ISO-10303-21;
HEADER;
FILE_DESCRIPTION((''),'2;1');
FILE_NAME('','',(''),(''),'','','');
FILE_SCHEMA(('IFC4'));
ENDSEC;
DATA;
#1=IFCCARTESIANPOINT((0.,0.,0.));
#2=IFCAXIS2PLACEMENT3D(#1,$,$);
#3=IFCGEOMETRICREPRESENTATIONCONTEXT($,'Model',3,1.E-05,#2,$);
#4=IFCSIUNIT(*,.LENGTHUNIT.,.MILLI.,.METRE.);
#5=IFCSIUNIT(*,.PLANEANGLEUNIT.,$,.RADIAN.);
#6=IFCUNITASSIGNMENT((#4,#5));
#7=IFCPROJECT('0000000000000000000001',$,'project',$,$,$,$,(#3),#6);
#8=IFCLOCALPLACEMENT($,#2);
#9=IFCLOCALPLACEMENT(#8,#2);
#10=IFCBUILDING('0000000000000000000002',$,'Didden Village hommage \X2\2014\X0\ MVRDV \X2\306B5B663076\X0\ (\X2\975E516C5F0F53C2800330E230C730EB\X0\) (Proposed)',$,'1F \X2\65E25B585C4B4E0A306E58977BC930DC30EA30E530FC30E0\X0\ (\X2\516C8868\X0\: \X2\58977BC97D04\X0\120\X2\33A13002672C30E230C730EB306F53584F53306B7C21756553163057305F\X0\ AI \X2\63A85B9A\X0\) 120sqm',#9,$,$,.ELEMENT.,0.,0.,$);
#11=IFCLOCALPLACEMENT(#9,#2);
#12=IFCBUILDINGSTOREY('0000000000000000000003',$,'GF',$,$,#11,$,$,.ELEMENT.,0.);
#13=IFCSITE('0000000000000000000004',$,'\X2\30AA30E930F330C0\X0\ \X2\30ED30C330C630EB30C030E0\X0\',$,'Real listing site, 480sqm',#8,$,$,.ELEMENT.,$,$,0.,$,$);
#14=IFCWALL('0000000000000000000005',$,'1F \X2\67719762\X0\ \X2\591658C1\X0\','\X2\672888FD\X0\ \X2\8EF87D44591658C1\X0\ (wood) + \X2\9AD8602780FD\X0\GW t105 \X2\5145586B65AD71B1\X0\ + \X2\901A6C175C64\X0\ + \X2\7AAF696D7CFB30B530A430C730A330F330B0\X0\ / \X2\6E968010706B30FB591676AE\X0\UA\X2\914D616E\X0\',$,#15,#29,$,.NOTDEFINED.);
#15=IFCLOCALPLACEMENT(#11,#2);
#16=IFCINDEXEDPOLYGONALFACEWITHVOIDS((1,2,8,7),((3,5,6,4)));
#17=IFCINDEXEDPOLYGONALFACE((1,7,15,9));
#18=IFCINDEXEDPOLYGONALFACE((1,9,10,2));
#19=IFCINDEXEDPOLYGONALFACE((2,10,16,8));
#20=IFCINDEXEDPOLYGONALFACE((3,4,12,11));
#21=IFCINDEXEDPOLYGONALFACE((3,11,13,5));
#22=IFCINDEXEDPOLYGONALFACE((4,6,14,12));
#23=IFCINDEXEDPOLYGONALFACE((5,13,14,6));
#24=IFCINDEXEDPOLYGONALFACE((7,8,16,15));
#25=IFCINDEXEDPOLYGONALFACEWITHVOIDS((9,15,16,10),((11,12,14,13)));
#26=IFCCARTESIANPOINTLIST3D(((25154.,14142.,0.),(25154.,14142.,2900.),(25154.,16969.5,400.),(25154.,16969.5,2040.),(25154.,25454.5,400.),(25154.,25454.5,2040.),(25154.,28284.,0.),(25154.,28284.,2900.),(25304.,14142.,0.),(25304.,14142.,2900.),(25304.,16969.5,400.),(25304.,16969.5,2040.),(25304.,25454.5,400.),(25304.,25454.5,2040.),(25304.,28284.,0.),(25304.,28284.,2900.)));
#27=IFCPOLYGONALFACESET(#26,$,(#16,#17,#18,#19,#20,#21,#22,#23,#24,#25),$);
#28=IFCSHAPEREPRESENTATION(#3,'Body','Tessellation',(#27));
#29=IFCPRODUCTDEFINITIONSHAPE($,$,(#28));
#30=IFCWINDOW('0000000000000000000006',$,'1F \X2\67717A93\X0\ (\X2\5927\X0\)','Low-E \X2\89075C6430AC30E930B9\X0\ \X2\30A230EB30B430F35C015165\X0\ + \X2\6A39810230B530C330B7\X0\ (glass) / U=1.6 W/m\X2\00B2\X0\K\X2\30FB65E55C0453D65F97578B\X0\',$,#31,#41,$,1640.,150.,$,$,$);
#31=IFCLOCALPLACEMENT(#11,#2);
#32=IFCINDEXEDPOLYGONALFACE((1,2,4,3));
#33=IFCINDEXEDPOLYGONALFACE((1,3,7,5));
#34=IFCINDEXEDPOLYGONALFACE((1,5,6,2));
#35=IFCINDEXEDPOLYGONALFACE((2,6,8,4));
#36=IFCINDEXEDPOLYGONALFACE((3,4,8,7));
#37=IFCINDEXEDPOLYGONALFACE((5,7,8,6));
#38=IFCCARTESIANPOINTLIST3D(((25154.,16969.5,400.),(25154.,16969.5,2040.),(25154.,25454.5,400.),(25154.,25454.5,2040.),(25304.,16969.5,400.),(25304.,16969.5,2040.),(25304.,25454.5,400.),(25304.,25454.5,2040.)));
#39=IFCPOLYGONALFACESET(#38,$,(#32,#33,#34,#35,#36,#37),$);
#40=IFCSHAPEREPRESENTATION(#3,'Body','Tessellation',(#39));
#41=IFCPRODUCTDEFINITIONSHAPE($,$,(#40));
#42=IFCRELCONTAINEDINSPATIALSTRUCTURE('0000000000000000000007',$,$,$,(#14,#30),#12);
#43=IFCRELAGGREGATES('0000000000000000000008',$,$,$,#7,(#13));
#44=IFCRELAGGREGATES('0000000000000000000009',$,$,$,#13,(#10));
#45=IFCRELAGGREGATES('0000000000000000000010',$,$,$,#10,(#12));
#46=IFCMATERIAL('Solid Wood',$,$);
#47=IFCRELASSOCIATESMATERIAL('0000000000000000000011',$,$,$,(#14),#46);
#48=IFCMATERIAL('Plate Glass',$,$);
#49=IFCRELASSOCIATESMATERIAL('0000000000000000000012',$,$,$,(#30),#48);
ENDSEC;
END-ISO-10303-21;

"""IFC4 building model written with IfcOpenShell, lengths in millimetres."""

from ifc_helpers import new_model, si_unit, frame, frame_2d, origin, place, context, project, spatial, rectangle, extrude, material, element, fill, save


model = new_model("IFC4")

# Units and contexts
model_context = context("Model", 3, precision=1e-05, world=origin())
ifc_project = project(units=[si_unit("LENGTHUNIT", "METRE", prefix="MILLI"), si_unit("PLANEANGLEUNIT", "RADIAN")], contexts=[model_context])

# Site, building, storey
site_placement = place(None, origin())
site = spatial("IfcSite", under=ifc_project, at=site_placement, Name="オランダ ロッテルダム", ObjectType="Real listing site, 480sqm", CompositionType="ELEMENT", RefElevation=0.0)
building_placement = place(site_placement, origin())
building = spatial("IfcBuilding", under=site, at=building_placement, Name="Didden Village hommage — MVRDV に学ぶ (非公式参考モデル) (Proposed)", ObjectType="1F 既存屋上の増築ボリューム (公表: 増築約120㎡。本モデルは単体に簡略化した AI 推定) 120sqm", CompositionType="ELEMENT", ElevationOfRefHeight=0.0, ElevationOfTerrain=0.0)
storey_placement = place(building_placement, origin())
storey = spatial("IfcBuildingStorey", under=building, at=storey_placement, Name="GF", CompositionType="ELEMENT", Elevation=0.0)

# Shared definitions
ifc_material_1 = material(Name="Solid Wood")

# Shared definitions
ifc_material_2 = material(Name="Plate Glass")

# Wall, opening, window
wall_1_placement = place(storey_placement, frame((12577.0, 7071.0, 0.0)))
wall_1 = element("IfcWall", 1, at=wall_1_placement, inside=storey, material=ifc_material_1, Name="1F 東面 外壁", Description="木製 軸組外壁 (wood) + 高性能GW t105 充填断熱 + 通気層 + 窯業系サイディング / 準耐火・外皮UA配慮", PredefinedType="NOTDEFINED", context=model_context, shape_type="SweptSolid", body=[
    extrude(rectangle(XDim=150.0, YDim=14142.0, at=frame_2d((75.0, 7071.0))), frame((12577.0, 7071.0, 0.0)), (0.0, 0.0, 1.0), 2900.0),
])
opening_1_placement = place(storey_placement, frame((12577.0, 8485.0, 200.0)))
opening_1 = element("IfcOpeningElement", 2, at=opening_1_placement, cuts=wall_1, PredefinedType="NOTDEFINED", context=model_context, shape_type="SweptSolid", body=[
    extrude(rectangle(XDim=150.0, YDim=8485.0, at=frame_2d((75.0, 4242.0))), frame((12577.0, 8485.0, 200.0)), (0.0, 0.0, 1.0), 1640.0),
])
window_1_placement = place(storey_placement, frame((12577.0, 8485.0, 200.0)))
window_1 = element("IfcWindow", 3, at=window_1_placement, inside=storey, material=ifc_material_2, Name="1F 東窓 (大)", Description="Low-E 複層ガラス アルゴン封入 + 樹脂サッシ (glass) / U=1.6 W/m²K・日射取得型", OverallHeight=1640.0, OverallWidth=150.0, context=model_context, shape_type="SweptSolid", body=[
    extrude(rectangle(XDim=150.0, YDim=8485.0, at=frame_2d((75.0, 4242.0))), frame((12577.0, 8485.0, 200.0)), (0.0, 0.0, 1.0), 1640.0),
])
fill(opening_1, window_1)

save(model, "model.ifc")
